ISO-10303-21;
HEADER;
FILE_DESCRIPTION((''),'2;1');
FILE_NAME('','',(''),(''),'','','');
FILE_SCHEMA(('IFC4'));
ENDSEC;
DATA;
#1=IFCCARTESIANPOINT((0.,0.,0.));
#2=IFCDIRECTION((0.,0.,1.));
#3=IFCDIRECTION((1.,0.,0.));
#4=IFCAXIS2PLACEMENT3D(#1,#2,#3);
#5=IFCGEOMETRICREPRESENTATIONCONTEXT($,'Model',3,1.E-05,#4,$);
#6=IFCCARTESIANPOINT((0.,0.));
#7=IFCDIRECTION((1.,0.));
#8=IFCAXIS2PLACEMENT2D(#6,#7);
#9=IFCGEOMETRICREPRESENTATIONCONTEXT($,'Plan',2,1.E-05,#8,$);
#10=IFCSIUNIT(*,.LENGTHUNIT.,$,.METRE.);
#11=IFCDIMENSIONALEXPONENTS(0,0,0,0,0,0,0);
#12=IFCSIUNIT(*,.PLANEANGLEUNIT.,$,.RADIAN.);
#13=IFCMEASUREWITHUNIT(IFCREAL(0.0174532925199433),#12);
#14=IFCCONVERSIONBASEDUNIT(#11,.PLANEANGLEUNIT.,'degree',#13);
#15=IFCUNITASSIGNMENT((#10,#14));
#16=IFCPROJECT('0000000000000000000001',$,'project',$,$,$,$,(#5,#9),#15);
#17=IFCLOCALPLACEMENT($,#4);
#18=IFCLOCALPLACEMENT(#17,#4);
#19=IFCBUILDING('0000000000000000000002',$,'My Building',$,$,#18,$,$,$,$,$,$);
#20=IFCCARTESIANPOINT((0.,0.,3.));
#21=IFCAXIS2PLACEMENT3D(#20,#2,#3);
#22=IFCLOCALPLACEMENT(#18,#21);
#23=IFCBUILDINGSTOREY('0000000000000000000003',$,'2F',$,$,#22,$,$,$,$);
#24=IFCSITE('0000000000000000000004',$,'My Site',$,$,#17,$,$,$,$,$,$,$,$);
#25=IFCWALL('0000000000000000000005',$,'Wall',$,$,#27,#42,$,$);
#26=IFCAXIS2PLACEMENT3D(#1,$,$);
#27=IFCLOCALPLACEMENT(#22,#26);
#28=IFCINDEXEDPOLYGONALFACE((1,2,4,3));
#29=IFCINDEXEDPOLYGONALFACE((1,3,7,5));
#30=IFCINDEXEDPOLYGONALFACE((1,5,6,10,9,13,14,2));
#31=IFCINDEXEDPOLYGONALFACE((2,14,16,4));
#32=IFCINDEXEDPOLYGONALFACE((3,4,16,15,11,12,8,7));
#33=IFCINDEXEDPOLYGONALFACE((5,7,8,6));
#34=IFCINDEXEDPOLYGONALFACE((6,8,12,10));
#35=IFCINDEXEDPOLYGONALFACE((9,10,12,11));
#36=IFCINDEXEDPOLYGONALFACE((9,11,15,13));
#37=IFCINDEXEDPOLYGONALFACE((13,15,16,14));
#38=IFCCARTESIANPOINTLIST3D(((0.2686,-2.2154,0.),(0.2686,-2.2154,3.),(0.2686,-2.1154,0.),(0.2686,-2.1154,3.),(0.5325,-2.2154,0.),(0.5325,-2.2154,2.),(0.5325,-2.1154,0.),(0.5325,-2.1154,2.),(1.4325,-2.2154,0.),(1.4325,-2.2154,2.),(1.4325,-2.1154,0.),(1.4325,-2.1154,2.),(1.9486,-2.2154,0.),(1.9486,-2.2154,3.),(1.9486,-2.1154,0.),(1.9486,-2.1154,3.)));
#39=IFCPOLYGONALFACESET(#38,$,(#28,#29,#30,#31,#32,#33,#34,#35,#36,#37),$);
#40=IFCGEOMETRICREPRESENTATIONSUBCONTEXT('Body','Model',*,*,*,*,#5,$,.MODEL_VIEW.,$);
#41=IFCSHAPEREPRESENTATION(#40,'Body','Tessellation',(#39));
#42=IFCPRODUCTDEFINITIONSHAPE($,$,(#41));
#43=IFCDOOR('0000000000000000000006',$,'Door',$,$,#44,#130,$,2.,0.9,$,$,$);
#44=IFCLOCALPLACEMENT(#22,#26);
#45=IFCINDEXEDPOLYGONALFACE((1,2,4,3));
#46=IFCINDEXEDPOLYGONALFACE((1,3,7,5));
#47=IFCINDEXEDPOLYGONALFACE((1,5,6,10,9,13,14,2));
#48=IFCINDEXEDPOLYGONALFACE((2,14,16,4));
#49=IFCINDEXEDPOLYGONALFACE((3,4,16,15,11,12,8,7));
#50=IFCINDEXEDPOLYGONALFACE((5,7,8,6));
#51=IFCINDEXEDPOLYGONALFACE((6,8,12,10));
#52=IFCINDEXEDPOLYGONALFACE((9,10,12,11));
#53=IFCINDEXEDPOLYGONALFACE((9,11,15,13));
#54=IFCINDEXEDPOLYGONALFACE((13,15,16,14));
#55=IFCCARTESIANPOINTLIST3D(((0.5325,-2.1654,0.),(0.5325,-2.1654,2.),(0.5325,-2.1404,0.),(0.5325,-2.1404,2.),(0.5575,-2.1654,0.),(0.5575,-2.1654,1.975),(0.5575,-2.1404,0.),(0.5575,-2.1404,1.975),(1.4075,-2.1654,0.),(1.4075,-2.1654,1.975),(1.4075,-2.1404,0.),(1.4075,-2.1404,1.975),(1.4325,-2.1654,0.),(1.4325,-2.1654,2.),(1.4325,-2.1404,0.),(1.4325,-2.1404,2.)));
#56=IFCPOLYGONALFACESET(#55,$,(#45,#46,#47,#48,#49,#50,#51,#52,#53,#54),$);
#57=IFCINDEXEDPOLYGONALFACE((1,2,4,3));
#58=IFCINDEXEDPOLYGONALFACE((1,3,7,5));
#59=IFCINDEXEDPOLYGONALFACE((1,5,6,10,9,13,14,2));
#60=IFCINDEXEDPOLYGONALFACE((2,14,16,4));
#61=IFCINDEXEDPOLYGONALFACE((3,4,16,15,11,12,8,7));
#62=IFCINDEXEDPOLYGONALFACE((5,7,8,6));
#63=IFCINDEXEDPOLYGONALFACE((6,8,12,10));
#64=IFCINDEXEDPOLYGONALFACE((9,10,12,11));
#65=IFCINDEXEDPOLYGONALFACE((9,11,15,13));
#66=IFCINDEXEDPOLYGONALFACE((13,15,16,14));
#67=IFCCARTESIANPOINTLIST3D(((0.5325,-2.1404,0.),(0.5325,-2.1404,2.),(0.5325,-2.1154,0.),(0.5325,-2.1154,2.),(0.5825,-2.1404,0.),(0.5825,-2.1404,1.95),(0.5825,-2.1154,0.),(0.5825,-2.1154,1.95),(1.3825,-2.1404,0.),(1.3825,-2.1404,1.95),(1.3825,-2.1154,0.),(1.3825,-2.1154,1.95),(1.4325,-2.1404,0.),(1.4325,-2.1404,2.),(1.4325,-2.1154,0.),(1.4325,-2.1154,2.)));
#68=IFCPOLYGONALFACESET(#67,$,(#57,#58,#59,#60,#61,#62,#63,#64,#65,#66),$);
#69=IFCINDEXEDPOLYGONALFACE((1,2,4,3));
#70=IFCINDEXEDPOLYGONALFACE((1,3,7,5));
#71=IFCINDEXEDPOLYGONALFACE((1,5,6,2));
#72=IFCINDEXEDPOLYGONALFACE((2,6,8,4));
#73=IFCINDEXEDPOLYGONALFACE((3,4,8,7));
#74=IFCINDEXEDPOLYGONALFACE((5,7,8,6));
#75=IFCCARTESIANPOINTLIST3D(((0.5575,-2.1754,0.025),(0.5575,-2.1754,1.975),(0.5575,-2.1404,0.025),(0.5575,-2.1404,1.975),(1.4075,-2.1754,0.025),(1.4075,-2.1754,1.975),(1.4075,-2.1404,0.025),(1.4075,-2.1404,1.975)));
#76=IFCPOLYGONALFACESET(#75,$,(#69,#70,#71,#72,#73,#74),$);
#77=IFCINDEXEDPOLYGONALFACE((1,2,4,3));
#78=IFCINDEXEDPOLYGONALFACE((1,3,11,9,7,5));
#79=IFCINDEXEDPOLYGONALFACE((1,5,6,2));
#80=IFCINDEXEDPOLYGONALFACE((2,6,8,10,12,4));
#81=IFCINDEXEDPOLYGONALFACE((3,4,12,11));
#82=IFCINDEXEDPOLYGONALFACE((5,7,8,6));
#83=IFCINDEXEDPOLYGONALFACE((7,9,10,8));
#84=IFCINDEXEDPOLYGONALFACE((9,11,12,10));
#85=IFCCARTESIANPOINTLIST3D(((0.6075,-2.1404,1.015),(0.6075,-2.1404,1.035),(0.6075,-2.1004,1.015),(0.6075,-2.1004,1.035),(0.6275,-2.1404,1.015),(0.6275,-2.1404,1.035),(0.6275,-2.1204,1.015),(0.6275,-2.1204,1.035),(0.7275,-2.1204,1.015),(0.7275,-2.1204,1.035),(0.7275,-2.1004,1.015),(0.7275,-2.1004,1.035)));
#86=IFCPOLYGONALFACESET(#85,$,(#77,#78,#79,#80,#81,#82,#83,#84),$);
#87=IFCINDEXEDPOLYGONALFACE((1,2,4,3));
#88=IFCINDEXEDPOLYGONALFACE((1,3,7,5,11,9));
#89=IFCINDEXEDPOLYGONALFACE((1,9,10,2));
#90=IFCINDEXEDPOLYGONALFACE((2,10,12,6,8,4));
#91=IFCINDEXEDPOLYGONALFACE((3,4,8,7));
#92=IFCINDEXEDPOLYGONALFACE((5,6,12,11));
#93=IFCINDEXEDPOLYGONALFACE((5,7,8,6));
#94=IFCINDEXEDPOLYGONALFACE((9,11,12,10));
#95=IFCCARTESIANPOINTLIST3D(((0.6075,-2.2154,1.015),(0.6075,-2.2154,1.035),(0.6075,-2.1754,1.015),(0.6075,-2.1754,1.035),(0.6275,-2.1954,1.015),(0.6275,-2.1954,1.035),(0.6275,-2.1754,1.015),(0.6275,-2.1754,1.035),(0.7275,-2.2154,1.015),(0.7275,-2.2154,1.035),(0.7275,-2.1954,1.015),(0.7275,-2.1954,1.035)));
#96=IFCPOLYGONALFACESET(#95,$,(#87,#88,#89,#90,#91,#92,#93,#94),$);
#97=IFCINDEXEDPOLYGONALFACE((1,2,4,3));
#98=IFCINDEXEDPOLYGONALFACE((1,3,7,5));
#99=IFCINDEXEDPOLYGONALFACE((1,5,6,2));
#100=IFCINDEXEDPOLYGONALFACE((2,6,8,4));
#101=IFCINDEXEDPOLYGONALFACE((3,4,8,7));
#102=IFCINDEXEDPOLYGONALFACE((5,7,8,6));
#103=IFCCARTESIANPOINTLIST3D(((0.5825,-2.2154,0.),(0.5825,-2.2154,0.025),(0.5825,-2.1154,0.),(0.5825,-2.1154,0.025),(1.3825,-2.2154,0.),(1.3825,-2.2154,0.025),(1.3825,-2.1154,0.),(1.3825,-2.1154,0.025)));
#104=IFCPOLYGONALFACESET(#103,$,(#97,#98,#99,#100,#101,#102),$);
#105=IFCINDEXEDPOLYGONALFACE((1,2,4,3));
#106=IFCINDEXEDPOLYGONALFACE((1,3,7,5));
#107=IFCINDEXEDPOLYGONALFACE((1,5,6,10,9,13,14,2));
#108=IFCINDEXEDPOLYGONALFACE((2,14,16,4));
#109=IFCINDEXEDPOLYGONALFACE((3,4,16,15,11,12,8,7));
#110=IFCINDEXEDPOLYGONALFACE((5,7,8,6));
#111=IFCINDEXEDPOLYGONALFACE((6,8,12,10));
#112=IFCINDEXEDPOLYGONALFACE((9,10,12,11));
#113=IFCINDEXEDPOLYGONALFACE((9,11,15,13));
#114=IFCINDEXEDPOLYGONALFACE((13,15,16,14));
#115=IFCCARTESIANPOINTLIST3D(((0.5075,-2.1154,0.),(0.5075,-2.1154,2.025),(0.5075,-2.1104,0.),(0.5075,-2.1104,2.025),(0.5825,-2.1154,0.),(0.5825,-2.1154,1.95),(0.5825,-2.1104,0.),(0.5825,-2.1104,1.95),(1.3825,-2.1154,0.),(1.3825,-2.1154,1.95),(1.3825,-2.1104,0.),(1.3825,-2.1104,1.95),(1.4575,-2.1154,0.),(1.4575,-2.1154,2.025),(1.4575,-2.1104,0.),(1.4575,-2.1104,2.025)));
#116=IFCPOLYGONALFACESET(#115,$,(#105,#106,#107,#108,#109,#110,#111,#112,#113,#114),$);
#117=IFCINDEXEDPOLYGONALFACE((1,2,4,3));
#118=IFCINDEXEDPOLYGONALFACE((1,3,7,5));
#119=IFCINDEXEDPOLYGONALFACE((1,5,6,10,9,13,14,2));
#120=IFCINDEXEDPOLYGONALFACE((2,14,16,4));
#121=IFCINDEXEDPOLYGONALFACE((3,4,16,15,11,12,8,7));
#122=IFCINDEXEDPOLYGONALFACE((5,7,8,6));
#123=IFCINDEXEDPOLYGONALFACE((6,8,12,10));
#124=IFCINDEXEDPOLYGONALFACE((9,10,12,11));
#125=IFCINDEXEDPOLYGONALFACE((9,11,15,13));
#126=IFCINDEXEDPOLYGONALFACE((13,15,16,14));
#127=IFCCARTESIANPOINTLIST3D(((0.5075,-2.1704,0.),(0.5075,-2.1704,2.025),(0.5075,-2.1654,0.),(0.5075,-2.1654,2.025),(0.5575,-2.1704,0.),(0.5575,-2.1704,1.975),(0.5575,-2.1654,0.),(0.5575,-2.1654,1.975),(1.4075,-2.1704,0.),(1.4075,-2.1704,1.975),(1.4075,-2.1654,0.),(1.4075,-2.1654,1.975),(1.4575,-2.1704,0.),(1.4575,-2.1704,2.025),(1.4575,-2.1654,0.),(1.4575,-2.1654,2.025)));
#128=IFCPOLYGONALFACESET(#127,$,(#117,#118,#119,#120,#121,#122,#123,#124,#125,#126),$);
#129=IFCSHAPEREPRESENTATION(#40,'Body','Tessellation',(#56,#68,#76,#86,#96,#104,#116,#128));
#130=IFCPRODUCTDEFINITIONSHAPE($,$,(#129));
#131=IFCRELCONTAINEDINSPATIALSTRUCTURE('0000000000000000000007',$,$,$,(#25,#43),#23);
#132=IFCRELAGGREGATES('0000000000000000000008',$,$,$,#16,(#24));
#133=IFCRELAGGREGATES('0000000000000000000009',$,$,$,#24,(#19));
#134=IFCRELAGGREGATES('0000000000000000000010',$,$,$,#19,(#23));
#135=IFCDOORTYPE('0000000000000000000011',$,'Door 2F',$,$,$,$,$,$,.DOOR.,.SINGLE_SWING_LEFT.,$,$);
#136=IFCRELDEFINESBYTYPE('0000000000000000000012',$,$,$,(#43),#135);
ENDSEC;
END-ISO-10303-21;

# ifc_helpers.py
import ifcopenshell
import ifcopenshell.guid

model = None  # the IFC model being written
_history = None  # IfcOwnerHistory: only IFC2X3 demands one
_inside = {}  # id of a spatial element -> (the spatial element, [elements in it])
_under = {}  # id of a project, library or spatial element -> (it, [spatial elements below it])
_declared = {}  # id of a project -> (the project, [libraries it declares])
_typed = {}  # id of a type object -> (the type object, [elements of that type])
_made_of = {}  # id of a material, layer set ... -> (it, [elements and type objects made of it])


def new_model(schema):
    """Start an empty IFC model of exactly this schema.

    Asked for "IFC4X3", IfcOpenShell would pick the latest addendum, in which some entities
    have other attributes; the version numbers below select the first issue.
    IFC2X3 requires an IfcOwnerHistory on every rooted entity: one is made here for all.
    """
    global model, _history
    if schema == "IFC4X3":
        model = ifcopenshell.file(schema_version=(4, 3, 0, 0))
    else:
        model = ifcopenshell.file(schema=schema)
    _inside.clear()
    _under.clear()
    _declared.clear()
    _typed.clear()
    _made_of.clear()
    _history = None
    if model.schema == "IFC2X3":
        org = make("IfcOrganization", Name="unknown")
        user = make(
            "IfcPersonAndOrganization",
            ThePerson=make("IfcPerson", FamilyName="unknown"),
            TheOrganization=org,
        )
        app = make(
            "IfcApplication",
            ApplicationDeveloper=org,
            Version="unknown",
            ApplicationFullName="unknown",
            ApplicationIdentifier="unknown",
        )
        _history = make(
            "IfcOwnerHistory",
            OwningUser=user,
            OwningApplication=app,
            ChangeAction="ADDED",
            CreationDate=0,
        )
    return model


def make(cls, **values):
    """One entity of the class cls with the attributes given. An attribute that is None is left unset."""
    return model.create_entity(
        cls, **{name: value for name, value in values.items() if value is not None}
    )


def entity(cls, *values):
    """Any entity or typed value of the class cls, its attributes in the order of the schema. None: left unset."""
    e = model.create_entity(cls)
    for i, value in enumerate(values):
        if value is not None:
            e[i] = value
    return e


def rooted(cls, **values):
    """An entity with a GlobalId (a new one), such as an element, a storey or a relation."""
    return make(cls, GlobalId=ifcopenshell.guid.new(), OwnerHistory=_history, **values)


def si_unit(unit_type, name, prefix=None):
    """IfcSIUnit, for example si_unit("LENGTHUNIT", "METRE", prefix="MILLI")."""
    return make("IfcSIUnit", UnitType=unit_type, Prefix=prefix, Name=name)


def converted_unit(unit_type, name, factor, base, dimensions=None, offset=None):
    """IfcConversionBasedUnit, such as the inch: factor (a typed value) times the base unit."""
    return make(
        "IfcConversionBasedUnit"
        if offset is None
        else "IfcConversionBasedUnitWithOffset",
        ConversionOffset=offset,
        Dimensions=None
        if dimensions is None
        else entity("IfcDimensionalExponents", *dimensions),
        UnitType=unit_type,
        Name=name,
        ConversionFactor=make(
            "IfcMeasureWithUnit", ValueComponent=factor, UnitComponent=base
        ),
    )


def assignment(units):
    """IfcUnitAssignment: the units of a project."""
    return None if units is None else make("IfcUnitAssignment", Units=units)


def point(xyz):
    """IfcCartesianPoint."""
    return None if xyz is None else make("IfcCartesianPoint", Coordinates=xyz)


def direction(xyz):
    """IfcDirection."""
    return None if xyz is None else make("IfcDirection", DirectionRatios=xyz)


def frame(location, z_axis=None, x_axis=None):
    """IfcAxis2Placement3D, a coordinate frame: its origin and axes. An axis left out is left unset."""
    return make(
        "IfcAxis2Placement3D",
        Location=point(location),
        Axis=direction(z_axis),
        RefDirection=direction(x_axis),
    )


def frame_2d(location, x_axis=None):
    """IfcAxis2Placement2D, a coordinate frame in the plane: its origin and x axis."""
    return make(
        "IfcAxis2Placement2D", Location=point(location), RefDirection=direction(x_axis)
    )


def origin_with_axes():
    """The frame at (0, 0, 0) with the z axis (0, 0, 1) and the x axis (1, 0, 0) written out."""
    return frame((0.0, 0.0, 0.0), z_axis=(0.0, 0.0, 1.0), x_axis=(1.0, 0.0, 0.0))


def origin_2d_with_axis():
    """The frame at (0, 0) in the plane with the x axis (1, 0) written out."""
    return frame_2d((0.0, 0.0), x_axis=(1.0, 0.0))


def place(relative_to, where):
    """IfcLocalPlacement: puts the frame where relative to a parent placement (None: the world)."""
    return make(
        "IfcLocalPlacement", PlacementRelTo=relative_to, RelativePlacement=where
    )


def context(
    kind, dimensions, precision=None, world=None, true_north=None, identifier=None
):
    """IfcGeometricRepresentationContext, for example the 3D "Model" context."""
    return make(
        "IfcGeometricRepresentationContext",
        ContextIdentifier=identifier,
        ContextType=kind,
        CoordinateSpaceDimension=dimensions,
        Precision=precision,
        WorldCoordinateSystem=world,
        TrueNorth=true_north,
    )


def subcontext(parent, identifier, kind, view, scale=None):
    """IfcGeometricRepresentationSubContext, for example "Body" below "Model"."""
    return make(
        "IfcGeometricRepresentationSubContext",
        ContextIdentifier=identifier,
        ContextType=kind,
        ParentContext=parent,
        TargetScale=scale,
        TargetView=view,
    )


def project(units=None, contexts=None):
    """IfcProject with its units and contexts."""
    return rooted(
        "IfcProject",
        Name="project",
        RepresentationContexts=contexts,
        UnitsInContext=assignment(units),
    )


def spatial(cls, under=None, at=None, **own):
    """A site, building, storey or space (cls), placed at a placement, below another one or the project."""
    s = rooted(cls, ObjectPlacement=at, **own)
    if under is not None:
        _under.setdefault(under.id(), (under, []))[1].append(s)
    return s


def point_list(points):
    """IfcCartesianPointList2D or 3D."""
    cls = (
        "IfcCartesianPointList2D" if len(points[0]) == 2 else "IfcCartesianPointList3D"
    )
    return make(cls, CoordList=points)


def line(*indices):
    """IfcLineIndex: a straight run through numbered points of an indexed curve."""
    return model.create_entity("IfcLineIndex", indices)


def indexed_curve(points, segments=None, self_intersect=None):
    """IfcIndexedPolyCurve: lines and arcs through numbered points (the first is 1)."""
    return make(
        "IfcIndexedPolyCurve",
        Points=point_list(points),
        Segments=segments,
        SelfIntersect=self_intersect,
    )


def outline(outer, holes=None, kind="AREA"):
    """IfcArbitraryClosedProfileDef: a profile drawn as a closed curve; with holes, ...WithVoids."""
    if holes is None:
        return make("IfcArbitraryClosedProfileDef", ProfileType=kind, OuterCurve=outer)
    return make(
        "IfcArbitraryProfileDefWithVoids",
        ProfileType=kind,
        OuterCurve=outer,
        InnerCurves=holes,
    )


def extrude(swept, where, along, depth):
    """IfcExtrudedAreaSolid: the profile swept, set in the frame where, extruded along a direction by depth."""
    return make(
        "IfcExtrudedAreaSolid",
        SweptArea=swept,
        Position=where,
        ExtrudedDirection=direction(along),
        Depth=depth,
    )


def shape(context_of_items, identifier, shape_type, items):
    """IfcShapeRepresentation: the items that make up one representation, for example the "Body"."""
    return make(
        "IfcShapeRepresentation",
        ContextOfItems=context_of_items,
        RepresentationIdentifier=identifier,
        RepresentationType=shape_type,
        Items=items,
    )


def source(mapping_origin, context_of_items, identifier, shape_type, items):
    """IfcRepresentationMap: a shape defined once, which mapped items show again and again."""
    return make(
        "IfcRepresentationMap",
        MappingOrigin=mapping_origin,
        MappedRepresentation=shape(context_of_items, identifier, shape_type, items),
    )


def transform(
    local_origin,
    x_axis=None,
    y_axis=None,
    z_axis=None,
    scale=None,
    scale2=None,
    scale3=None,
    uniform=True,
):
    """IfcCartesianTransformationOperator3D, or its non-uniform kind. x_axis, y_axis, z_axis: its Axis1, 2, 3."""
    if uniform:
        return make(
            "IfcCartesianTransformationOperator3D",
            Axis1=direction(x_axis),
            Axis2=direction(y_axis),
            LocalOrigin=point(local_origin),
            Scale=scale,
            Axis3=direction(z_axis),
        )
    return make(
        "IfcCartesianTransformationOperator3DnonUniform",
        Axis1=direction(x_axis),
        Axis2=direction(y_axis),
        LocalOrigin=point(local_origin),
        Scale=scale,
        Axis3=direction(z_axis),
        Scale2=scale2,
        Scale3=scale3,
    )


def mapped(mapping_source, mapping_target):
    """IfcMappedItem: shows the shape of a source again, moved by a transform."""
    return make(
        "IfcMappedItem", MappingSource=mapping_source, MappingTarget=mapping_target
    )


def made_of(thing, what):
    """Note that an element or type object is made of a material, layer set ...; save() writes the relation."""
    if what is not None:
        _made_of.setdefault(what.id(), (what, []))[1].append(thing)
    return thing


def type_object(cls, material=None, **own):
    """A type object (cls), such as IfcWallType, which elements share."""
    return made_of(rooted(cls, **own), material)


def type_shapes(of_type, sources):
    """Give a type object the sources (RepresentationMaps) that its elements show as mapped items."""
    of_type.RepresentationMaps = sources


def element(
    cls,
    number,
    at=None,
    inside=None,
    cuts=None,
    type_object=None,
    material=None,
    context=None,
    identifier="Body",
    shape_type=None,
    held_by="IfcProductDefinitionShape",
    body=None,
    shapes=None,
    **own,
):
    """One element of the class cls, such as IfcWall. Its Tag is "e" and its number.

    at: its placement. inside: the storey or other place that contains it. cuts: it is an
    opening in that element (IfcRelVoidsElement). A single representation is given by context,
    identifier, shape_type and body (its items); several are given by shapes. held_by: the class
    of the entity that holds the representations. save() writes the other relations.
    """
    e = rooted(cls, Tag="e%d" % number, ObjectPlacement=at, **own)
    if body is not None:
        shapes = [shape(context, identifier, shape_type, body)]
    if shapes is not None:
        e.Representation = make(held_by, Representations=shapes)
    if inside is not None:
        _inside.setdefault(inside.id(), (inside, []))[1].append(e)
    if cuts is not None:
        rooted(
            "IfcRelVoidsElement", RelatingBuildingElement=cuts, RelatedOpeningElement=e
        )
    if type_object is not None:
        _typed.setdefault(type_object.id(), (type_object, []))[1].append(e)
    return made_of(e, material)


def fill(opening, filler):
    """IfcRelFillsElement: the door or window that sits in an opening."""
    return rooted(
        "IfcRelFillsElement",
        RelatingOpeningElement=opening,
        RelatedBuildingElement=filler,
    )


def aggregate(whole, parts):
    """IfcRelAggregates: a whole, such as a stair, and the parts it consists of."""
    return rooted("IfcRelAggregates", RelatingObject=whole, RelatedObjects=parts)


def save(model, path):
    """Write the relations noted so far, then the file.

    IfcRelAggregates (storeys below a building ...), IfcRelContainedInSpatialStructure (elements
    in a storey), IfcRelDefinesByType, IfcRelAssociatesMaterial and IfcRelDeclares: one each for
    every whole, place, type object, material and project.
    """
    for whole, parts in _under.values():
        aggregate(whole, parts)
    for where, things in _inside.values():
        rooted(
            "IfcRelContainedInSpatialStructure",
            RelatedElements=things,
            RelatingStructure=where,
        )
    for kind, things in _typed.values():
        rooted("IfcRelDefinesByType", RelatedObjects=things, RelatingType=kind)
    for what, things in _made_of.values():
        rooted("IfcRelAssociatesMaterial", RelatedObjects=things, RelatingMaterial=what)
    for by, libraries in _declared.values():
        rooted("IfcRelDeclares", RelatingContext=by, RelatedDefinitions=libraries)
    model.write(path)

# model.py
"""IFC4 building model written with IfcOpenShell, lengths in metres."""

from ifc_helpers import new_model, entity, si_unit, converted_unit, frame, origin_with_axes, origin_2d_with_axis, place, context, subcontext, project, spatial, line, indexed_curve, outline, extrude, shape, source, transform, mapped, type_object, type_shapes, element, fill, save


model = new_model("IFC4")

# Units and contexts
model_context = context("Model", 3, precision=1e-05, world=origin_with_axes())
plan_context = context("Plan", 2, precision=1e-05, world=origin_2d_with_axis())
body_context_1 = subcontext(model_context, "Body", "Model", "MODEL_VIEW")
body_context_2 = subcontext(plan_context, "Body", "Plan", "PLAN_VIEW")
ifc_project = project(units=[si_unit("LENGTHUNIT", "METRE"), converted_unit("PLANEANGLEUNIT", "degree", entity("IfcReal", 0.0174532925199433), si_unit("PLANEANGLEUNIT", "RADIAN"), dimensions=[0, 0, 0, 0, 0, 0, 0])], contexts=[model_context, plan_context])

# Site, building, storey
site_placement = place(None, origin_with_axes())
site = spatial("IfcSite", under=ifc_project, at=site_placement, Name="My Site")
building_placement = place(site_placement, origin_with_axes())
building = spatial("IfcBuilding", under=site, at=building_placement, Name="My Building")
storey_placement = place(building_placement, frame((0.0, 0.0, 3.0), z_axis=(0.0, 0.0, 1.0), x_axis=(1.0, 0.0, 0.0)))
storey = spatial("IfcBuildingStorey", under=building, at=storey_placement, Name="2F")

# Shared definitions
shared_shape_1 = source(origin_with_axes(), body_context_1, "Body", "SweptSolid", [
    extrude(outline(indexed_curve([(0.0, 0.0), (0.9, 0.0), (0.9, 2.0), (0.0, 2.0)], segments=[line(1, 2, 3, 4, 1)])), frame((0.0, -0.6, 0.0), z_axis=(0.0, -1.0, 0.0), x_axis=(1.0, 0.0, 0.0)), (0.0, 0.0, -1.0), 1.2),
])
door_type = type_object("IfcDoorType", Name="Door 2F", OperationType="SINGLE_SWING_LEFT", PredefinedType="DOOR")
shared_shape_2 = source(origin_with_axes(), body_context_1, "Body", "SweptSolid", [
    extrude(outline(indexed_curve([(0.0, 0.0), (0.0, 2.0), (0.9, 2.0), (0.9, 0.0), (0.875, 0.0), (0.875, 1.975), (0.025, 1.975), (0.025, 0.0)], segments=[line(1, 2, 3, 4, 5, 6, 7, 8, 1)])), frame((0.0, 0.025, 0.0), z_axis=(0.0, -1.0, 0.0), x_axis=(1.0, 0.0, 0.0)), (0.0, 0.0, -1.0), 0.025),
    extrude(outline(indexed_curve([(0.0, 0.0), (0.0, 2.0), (0.9, 2.0), (0.9, 0.0), (0.85, 0.0), (0.85, 1.95), (0.05, 1.95), (0.05, 0.0)], segments=[line(1, 2, 3, 4, 5, 6, 7, 8, 1)])), frame((0.0, 0.0, 0.0), z_axis=(0.0, -1.0, 0.0), x_axis=(1.0, 0.0, 0.0)), (0.0, 0.0, -1.0), 0.025),
    extrude(outline(indexed_curve([(0.0, 0.0), (0.85, 0.0), (0.85, 0.035), (0.0, 0.035)], segments=[line(1, 2, 3, 4, 1)])), frame((0.025, 0.025, 0.025), z_axis=(0.0, 0.0, 1.0), x_axis=(1.0, 0.0, 0.0)), (0.0, 0.0, 1.0), 1.95),
    extrude(outline(indexed_curve([(0.0, 0.0), (0.0, -0.04), (-0.12, -0.04), (-0.12, -0.02), (-0.02, -0.02), (-0.02, 0.0)], segments=[line(1, 2, 3, 4, 5, 6, 1)])), frame((0.825, 0.025, 1.015), z_axis=(0.0, 0.0, 1.0), x_axis=(1.0, 0.0, 0.0)), (0.0, 0.0, 1.0), 0.02),
    extrude(outline(indexed_curve([(0.0, 0.0), (0.0, 0.04), (-0.12, 0.04), (-0.12, 0.02), (-0.02, 0.02), (-0.02, 0.0)], segments=[line(1, 2, 3, 4, 5, 6, 1)])), frame((0.825, 0.06, 1.015), z_axis=(0.0, 0.0, 1.0), x_axis=(1.0, 0.0, 0.0)), (0.0, 0.0, 1.0), 0.02),
    extrude(outline(indexed_curve([(0.0, 0.0), (0.8, 0.0), (0.8, 0.1), (0.0, 0.1)], segments=[line(1, 2, 3, 4, 1)])), frame((0.05, 0.0, 0.0), z_axis=(0.0, 0.0, 1.0), x_axis=(1.0, 0.0, 0.0)), (0.0, 0.0, 1.0), 0.025),
    extrude(outline(indexed_curve([(0.0, 0.0), (0.0, 2.025), (0.95, 2.025), (0.95, 0.0), (0.875, 0.0), (0.875, 1.95), (0.075, 1.95), (0.075, 0.0)], segments=[line(1, 2, 3, 4, 5, 6, 7, 8, 1)])), frame((-0.025, -0.005, 0.0), z_axis=(0.0, -1.0, 0.0), x_axis=(1.0, 0.0, 0.0)), (0.0, 0.0, -1.0), 0.005),
    extrude(outline(indexed_curve([(0.0, 0.0), (0.0, 2.025), (0.95, 2.025), (0.95, 0.0), (0.9, 0.0), (0.9, 1.975), (0.05, 1.975), (0.05, 0.0)], segments=[line(1, 2, 3, 4, 5, 6, 7, 8, 1)])), frame((-0.025, 0.05, 0.0), z_axis=(0.0, -1.0, 0.0), x_axis=(1.0, 0.0, 0.0)), (0.0, 0.0, -1.0), 0.005),
])
shared_shape_3 = source(origin_with_axes(), body_context_2, "Body", "Curve2D", [
    entity("IfcIndexedPolyCurve", entity("IfcCartesianPointList2D", [[0.0, 0.0], [0.0, 0.05], [0.025, 0.05], [0.025, 0.025], [0.05, 0.025], [0.05, 0.0]]), [entity("IfcLineIndex", [1, 2, 3, 4, 5, 6, 1])]),
    entity("IfcIndexedPolyCurve", entity("IfcCartesianPointList2D", [[0.9, 0.0], [0.9, 0.05], [0.875, 0.05], [0.875, 0.025], [0.85, 0.025], [0.85, 0.0]]), [entity("IfcLineIndex", [1, 2, 3, 4, 5, 6, 1])]),
    entity("IfcTrimmedCurve", entity("IfcEllipse", entity("IfcAxis2Placement2D", entity("IfcCartesianPoint", [0.06, 0.05]), entity("IfcDirection", [1.0, 0.0])), 0.815, 0.85), [entity("IfcCartesianPoint", [0.875, 0.05])], [entity("IfcCartesianPoint", [0.06, 0.9])], True, "CARTESIAN"),
    entity("IfcIndexedPolyCurve", entity("IfcCartesianPointList2D", [[0.025, 0.05], [0.06, 0.05], [0.06, 0.9], [0.025, 0.9]]), [entity("IfcLineIndex", [1, 2, 3, 4, 1])]),
])
type_shapes(door_type, [shared_shape_2, shared_shape_3])

# Wall, opening, door
wall_1_placement = place(storey_placement, frame((1.9486, -2.1154, 0.0), z_axis=(0.0, 0.0, 1.0), x_axis=(-1.0, 0.0, 0.0)))
wall_1 = element("IfcWall", 1, at=wall_1_placement, inside=storey, Name="Wall", context=body_context_1, shape_type="SweptSolid", body=[
    extrude(outline(indexed_curve([(0.0, 0.0), (0.0, 0.1), (1.68, 0.1), (1.68, 0.0)], segments=[line(1, 2, 3, 4, 1)])), origin_with_axes(), (0.0, 0.0, 1.0), 3.0),
])
opening_1_placement = place(wall_1_placement, frame((0.5161, 0.0, 0.0), z_axis=(0.0, 0.0, 1.0), x_axis=(1.0, 0.0, 0.0)))
opening_1 = element("IfcOpeningElement", 2, at=opening_1_placement, cuts=wall_1, PredefinedType="OPENING", context=body_context_1, shape_type="MappedRepresentation", body=[
    mapped(shared_shape_1, transform((0.0, 0.0, 0.0), x_axis=(1.0, 0.0, 0.0), y_axis=(0.0, 1.0, 0.0), z_axis=(0.0, 0.0, 1.0), scale=1.0)),
])
door_1_placement = place(opening_1_placement, origin_with_axes())
door_1 = element("IfcDoor", 3, at=door_1_placement, inside=storey, type_object=door_type, Name="Door", OverallHeight=2.0, OverallWidth=0.9, shapes=[
    shape(body_context_1, "Body", "MappedRepresentation", [mapped(shared_shape_2, transform((0.0, 0.0, 0.0), x_axis=(1.0, 0.0, 0.0), y_axis=(0.0, 1.0, 0.0), z_axis=(0.0, 0.0, 1.0), scale=1.0))]),
    shape(body_context_2, "Body", "MappedRepresentation", [mapped(shared_shape_3, transform((0.0, 0.0, 0.0), x_axis=(1.0, 0.0, 0.0), y_axis=(0.0, 1.0, 0.0), z_axis=(0.0, 0.0, 1.0), scale=1.0))]),
])
fill(opening_1, door_1)

save(model, "model.ifc")
